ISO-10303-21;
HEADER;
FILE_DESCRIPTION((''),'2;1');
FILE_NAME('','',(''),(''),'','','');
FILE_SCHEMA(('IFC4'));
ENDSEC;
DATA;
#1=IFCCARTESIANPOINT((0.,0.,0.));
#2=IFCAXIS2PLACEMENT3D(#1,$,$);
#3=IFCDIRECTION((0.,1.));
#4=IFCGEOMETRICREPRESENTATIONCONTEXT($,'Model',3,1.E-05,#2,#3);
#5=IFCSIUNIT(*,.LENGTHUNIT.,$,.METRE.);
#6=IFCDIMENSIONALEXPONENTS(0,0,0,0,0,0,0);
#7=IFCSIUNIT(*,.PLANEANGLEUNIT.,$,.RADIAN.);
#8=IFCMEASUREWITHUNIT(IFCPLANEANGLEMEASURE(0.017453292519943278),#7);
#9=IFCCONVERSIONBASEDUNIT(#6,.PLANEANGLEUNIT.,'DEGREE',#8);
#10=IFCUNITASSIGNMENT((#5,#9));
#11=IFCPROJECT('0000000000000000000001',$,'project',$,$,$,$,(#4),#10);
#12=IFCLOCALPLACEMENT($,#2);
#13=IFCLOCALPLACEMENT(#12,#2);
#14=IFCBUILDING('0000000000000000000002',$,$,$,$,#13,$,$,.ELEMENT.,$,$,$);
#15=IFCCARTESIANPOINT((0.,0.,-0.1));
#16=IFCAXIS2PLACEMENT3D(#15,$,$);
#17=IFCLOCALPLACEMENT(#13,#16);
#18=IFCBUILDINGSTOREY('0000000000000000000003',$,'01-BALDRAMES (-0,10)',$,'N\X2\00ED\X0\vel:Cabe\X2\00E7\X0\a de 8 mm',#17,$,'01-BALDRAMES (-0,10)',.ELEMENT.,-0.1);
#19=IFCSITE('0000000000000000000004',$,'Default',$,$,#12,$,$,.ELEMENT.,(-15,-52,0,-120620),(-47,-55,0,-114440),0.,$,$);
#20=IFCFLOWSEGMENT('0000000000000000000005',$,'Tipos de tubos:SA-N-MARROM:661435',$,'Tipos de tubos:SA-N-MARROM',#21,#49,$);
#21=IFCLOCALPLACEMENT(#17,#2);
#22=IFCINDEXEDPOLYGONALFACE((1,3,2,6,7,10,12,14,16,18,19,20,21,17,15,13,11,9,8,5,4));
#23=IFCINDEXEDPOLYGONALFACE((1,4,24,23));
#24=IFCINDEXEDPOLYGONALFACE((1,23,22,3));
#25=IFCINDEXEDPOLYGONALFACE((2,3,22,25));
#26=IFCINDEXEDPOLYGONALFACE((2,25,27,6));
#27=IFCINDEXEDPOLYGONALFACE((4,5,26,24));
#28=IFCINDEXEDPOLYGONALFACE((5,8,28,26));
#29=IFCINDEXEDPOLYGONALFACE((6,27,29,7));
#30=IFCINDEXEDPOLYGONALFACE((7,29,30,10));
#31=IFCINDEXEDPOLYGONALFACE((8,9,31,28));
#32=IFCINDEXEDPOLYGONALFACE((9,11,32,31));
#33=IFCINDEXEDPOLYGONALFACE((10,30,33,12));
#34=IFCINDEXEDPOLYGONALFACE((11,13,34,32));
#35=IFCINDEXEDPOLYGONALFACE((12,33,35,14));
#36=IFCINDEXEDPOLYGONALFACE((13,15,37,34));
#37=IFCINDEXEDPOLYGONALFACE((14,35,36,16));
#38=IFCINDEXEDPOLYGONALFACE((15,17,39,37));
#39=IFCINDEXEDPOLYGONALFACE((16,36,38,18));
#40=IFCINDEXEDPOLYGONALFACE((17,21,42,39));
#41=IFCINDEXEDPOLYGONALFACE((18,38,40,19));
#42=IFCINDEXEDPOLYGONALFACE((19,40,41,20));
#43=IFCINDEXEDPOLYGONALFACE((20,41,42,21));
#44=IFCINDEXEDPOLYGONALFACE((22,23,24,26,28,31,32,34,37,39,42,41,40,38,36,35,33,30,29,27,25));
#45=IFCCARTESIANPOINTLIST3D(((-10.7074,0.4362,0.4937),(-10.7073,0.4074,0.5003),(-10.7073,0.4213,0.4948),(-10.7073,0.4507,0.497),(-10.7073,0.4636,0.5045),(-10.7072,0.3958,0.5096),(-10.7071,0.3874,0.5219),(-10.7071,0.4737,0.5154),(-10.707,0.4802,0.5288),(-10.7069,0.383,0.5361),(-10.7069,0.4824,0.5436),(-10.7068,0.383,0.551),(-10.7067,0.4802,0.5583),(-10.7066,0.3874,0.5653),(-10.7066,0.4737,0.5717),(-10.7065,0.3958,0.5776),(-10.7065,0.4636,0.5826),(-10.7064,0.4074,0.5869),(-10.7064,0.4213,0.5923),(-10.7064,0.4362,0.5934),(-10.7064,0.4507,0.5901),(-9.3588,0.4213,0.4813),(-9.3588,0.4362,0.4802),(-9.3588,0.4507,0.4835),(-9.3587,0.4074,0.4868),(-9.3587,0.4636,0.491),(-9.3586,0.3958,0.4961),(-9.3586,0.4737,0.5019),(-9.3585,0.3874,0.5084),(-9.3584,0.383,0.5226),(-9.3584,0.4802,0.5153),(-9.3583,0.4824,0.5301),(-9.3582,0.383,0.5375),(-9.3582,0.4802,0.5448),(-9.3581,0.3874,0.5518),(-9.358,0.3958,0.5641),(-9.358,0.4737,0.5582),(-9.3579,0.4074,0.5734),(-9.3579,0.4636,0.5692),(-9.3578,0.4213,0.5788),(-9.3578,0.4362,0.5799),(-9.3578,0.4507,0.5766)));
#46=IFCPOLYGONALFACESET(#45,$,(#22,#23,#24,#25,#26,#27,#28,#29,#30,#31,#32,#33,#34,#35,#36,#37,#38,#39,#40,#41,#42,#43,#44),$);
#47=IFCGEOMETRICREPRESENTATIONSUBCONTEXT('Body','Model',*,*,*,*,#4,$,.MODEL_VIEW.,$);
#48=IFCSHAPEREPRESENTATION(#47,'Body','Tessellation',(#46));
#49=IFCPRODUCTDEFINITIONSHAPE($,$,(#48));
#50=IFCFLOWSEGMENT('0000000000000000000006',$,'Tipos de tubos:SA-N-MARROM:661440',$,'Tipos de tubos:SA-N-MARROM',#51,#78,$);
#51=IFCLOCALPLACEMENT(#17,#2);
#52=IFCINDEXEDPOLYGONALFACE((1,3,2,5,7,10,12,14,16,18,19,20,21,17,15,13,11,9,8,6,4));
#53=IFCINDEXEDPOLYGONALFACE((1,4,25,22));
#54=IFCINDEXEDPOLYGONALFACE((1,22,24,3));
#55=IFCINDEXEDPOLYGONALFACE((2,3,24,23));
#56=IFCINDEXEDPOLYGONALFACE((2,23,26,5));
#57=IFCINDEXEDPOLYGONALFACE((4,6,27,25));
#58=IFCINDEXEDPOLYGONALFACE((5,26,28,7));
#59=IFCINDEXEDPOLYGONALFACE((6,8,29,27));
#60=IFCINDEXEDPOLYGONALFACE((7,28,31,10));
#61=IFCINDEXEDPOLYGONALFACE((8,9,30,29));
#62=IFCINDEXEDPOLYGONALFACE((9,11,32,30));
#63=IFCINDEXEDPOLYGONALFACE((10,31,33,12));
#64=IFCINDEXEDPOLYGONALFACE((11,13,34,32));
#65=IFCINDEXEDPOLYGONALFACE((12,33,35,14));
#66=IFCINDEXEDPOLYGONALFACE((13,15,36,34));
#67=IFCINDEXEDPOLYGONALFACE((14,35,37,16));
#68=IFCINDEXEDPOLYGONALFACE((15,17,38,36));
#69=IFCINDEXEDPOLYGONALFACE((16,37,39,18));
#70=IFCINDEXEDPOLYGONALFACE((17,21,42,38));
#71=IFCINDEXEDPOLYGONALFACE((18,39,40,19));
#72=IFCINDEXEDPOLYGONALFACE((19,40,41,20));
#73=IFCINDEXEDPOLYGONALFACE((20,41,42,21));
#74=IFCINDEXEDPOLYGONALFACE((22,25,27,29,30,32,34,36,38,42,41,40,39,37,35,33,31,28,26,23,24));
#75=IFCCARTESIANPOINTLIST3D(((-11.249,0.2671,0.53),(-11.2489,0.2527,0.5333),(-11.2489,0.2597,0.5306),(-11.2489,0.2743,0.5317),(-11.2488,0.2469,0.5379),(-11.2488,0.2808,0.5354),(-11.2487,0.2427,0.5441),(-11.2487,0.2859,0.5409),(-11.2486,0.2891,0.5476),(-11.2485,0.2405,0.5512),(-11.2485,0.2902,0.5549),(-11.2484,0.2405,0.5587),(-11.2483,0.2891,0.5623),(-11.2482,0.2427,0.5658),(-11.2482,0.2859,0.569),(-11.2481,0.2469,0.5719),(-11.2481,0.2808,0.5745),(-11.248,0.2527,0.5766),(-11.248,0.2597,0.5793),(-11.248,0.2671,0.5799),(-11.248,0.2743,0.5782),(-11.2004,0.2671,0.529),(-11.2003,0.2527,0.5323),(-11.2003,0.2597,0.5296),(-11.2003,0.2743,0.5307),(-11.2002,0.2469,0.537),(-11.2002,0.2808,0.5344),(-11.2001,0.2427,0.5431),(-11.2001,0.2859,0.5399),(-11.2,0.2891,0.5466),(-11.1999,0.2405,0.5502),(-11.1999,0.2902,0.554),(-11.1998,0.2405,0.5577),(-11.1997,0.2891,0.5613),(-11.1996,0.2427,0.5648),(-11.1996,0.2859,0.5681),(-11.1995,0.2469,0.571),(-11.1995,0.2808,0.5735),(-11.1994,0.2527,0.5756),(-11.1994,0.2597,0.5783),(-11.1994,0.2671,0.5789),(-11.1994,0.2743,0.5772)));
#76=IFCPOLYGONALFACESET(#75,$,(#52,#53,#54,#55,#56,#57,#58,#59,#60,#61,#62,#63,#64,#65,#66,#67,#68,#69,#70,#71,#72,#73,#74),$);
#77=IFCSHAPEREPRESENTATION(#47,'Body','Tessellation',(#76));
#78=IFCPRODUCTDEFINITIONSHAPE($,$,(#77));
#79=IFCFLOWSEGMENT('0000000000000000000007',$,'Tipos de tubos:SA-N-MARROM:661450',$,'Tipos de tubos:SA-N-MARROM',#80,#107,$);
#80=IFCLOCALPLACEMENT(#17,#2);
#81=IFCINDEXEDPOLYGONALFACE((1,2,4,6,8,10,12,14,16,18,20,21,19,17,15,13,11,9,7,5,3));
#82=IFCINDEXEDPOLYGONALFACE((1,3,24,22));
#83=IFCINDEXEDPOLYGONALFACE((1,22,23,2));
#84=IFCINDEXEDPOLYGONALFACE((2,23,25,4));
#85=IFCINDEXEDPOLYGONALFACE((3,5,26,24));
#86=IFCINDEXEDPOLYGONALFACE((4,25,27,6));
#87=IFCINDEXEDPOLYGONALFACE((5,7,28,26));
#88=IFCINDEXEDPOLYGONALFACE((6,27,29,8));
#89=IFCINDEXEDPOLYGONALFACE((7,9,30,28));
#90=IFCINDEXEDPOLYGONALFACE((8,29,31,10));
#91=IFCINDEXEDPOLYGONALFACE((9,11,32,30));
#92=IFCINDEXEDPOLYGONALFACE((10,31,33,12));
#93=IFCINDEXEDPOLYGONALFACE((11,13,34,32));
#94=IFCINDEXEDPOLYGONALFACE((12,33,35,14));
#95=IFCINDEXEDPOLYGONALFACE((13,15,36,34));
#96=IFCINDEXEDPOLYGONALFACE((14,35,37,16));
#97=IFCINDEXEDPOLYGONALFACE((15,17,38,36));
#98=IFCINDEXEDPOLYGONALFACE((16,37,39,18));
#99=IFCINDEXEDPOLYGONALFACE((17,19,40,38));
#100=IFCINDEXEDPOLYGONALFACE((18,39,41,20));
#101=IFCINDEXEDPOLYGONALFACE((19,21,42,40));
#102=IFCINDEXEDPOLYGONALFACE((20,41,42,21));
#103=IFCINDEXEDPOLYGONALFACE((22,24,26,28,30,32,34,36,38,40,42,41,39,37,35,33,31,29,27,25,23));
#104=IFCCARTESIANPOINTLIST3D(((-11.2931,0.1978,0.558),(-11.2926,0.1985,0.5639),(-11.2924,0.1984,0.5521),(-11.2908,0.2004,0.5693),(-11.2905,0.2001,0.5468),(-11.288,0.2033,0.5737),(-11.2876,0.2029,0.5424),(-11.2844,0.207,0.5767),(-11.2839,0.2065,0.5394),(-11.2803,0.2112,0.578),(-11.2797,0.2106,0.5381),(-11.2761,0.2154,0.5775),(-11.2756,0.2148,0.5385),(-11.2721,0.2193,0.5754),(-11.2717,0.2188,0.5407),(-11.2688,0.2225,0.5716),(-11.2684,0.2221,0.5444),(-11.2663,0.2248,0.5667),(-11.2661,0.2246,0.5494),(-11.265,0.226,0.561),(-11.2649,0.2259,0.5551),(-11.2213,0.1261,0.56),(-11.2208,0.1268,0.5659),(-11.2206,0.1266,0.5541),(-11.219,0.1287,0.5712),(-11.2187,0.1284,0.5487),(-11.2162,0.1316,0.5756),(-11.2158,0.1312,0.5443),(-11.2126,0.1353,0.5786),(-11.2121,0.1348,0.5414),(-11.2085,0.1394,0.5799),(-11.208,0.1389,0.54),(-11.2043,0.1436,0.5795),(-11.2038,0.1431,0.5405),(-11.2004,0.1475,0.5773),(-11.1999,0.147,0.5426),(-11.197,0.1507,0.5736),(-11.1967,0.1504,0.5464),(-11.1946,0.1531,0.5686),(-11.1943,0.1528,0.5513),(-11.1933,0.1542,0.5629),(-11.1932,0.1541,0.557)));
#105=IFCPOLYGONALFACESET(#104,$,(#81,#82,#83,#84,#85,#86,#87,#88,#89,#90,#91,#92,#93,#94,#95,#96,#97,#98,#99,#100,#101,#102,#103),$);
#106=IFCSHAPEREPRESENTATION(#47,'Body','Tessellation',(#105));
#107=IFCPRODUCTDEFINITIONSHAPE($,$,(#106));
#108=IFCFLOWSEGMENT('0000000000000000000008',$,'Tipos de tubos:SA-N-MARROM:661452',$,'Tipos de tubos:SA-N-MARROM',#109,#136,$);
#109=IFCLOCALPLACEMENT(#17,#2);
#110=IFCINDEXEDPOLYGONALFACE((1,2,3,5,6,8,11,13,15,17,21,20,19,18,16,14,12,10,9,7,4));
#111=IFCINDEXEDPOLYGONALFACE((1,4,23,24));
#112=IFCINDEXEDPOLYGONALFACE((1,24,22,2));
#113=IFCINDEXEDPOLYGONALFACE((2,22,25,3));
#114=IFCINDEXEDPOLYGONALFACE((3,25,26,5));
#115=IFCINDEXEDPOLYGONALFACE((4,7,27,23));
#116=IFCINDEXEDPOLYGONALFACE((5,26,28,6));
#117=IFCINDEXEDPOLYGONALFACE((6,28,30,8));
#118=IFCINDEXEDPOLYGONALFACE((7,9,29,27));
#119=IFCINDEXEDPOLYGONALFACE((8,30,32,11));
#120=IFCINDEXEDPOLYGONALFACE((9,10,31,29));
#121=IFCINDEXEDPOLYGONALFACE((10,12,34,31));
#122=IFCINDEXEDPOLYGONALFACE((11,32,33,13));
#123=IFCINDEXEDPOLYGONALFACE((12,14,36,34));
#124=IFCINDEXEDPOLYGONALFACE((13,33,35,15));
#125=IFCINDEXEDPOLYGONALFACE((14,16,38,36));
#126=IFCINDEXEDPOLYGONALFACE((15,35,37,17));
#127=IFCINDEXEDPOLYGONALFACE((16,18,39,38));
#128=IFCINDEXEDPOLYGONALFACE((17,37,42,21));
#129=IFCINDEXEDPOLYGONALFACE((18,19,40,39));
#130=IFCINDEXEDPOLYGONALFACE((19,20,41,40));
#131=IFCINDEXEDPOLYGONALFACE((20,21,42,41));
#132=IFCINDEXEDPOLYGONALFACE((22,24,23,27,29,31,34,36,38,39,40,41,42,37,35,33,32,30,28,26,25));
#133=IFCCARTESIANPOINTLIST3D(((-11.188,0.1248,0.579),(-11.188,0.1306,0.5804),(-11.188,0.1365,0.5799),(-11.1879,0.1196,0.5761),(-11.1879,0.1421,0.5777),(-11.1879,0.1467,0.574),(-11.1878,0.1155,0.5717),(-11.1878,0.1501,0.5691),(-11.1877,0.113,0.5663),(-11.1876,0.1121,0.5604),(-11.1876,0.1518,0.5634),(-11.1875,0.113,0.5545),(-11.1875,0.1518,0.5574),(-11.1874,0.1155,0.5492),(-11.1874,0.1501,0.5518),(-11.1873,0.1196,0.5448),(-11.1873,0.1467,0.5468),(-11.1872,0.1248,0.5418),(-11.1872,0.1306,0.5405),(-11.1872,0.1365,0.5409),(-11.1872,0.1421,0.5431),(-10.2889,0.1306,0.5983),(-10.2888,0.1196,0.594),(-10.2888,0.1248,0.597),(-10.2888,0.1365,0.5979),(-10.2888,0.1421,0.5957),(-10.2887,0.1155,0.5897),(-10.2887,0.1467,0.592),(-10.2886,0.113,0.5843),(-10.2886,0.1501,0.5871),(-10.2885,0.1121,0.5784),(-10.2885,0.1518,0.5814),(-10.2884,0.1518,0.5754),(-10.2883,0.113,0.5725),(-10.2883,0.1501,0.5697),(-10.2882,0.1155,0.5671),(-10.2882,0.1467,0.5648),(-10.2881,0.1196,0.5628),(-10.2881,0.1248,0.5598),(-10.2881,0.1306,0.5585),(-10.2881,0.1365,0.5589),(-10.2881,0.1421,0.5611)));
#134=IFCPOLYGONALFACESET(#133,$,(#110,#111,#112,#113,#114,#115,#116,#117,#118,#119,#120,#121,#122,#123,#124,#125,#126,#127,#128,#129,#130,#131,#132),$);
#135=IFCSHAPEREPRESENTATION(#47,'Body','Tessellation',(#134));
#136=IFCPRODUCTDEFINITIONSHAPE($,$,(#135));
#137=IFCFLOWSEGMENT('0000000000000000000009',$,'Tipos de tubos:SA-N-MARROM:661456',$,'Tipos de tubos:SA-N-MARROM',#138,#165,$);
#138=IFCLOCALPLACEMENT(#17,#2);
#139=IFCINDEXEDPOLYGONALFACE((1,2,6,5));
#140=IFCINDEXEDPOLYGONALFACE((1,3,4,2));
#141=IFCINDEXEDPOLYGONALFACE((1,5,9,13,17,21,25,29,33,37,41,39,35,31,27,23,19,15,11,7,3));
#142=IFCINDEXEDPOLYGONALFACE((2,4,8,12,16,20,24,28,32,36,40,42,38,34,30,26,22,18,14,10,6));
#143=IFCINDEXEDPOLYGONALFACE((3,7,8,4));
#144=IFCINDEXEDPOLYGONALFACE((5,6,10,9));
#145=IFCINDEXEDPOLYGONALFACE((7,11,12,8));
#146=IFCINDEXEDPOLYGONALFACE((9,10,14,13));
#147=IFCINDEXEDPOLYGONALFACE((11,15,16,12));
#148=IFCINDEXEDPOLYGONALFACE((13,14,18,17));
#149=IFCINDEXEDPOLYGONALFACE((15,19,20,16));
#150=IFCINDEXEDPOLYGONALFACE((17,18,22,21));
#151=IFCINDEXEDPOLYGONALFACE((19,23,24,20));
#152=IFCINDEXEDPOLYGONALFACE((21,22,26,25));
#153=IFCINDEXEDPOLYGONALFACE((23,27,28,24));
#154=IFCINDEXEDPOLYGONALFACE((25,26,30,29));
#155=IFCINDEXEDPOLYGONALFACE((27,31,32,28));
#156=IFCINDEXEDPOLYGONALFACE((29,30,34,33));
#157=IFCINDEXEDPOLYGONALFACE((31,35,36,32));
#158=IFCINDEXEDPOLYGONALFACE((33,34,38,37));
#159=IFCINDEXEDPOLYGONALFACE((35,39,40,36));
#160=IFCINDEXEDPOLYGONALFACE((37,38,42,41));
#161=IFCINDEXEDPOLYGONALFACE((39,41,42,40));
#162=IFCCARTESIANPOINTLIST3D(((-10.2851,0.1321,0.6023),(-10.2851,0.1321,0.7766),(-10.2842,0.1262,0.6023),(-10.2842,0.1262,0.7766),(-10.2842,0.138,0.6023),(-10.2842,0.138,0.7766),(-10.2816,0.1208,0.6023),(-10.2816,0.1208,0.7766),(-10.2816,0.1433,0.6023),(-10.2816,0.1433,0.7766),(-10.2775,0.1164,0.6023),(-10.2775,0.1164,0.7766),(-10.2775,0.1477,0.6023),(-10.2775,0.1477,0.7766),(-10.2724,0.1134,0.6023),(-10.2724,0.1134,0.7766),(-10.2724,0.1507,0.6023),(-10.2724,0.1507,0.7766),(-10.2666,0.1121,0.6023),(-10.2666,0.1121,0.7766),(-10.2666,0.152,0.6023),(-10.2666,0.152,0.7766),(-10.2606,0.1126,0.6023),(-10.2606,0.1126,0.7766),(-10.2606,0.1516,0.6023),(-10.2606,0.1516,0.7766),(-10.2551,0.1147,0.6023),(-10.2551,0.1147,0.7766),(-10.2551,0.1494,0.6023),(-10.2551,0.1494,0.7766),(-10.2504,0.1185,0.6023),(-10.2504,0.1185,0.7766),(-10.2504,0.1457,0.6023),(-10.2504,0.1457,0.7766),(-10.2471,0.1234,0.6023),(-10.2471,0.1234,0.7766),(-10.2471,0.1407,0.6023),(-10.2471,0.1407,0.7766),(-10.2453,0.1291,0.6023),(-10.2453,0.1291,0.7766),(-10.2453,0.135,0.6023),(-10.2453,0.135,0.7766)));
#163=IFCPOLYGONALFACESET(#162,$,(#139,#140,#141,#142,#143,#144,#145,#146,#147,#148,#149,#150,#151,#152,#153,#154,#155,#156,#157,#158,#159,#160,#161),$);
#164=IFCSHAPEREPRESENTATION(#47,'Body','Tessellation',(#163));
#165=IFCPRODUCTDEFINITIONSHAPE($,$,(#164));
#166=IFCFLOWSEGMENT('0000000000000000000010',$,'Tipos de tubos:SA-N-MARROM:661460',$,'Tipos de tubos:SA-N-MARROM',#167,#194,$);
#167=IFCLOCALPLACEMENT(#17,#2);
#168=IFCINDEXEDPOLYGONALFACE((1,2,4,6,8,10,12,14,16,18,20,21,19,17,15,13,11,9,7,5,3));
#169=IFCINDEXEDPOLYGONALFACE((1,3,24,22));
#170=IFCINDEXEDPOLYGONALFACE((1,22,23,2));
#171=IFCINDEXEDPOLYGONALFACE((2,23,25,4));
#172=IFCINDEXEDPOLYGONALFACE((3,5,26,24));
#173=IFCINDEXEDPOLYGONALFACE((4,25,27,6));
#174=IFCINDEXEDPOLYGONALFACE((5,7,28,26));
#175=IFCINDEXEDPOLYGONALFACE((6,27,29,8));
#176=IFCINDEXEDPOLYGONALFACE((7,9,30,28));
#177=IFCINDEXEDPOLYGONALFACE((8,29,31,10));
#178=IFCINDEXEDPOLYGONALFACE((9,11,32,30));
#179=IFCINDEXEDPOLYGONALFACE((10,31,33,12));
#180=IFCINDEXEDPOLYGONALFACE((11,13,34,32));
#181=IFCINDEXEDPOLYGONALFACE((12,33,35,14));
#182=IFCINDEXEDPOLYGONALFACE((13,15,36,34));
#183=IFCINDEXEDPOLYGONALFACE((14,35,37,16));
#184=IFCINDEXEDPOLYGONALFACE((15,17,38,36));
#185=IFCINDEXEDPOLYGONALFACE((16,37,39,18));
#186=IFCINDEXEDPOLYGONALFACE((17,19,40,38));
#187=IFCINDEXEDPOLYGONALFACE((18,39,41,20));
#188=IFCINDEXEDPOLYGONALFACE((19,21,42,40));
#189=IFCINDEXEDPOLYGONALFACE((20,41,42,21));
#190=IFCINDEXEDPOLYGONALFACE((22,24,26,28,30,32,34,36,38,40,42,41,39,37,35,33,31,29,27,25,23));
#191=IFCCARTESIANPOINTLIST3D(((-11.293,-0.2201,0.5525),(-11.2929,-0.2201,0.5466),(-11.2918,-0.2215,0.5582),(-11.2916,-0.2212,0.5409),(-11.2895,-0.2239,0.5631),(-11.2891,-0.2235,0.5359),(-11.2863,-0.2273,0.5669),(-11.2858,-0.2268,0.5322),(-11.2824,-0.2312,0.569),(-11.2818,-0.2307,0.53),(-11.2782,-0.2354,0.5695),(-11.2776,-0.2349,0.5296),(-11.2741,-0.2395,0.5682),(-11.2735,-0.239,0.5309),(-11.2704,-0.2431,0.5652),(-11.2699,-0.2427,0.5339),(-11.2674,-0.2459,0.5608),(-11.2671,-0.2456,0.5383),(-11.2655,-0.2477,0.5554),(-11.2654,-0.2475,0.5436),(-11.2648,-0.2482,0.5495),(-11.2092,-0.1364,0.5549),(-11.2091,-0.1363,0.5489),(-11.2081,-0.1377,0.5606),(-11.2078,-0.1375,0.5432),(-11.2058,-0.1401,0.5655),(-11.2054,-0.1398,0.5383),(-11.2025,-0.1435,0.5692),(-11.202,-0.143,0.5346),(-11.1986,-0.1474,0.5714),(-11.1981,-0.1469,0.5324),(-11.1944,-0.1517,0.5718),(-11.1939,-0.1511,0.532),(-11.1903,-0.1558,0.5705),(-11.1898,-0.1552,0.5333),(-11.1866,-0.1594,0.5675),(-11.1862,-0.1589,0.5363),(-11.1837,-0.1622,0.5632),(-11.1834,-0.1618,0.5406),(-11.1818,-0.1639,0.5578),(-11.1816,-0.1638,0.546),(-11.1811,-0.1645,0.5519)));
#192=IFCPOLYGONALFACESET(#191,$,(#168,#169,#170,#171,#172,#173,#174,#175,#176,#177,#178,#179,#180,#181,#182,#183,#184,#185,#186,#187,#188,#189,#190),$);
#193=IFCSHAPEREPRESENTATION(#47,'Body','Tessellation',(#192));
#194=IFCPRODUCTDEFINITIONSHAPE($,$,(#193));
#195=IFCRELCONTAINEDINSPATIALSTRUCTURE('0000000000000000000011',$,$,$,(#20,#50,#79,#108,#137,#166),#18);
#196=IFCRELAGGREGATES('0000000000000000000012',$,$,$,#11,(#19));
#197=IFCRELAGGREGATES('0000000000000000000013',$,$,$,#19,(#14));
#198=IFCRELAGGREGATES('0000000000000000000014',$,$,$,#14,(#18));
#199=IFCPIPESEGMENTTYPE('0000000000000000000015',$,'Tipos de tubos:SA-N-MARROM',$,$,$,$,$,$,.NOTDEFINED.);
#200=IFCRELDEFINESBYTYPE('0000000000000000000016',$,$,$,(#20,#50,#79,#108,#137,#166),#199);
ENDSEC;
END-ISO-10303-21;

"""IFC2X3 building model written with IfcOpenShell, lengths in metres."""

from ifc_helpers import new_model, entity, si_unit, converted_unit, direction, frame, frame_2d, origin, place, context, subcontext, project, spatial, circle, extrude, type_object, element, save


model = new_model("IFC2X3")

# Units and contexts
model_context = context("Model", 3, precision=1e-05, world=origin(), true_north=direction((0.0, 1.0)))
body_context = subcontext(model_context, "Body", "Model", "MODEL_VIEW")
ifc_project = project(units=[si_unit("LENGTHUNIT", "METRE"), converted_unit("PLANEANGLEUNIT", "DEGREE", entity("IfcPlaneAngleMeasure", 0.017453292519943278), si_unit("PLANEANGLEUNIT", "RADIAN"), dimensions=[0, 0, 0, 0, 0, 0, 0])], contexts=[model_context])

# Site, building, storey
site_placement = place(None, origin())
site = spatial("IfcSite", under=ifc_project, at=site_placement, Name="Default", CompositionType="ELEMENT", RefLatitude=(-15, -52, 0, -120620), RefLongitude=(-47, -55, 0, -114440), RefElevation=0.0)
building_placement = place(site_placement, origin())
building = spatial("IfcBuilding", under=site, at=building_placement, CompositionType="ELEMENT")
storey_placement = place(building_placement, frame((0.0, 0.0, -0.1)))
storey = spatial("IfcBuildingStorey", under=building, at=storey_placement, Name="01-BALDRAMES (-0,10)", ObjectType="Nível:Cabeça de 8 mm", LongName="01-BALDRAMES (-0,10)", CompositionType="ELEMENT", Elevation=-0.1)

# Flow segments
pipe_segment_type_1 = type_object("IfcPipeSegmentType", Name="Tipos de tubos:SA-N-MARROM", PredefinedType="NOTDEFINED")
flow_segment_1_placement = place(storey_placement, origin())
element("IfcFlowSegment", 1, at=flow_segment_1_placement, inside=storey, type_object=pipe_segment_type_1, Name="Tipos de tubos:SA-N-MARROM:661435", ObjectType="Tipos de tubos:SA-N-MARROM", context=body_context, shape_type="SweptSolid", body=[
    extrude(circle(Radius=0.05, at=frame_2d((0.0, 0.0), x_axis=(1.0, 0.0))), frame((-10.7069, 0.4324, 0.5436), z_axis=(0.99995, 0.000001, -0.01), x_axis=(-0.000001, 1.0, 0.0)), (0.0, 0.0, 1.0), 1.3486),
])
flow_segment_2_placement = place(storey_placement, origin())
element("IfcFlowSegment", 2, at=flow_segment_2_placement, inside=storey, type_object=pipe_segment_type_1, Name="Tipos de tubos:SA-N-MARROM:661440", ObjectType="Tipos de tubos:SA-N-MARROM", context=body_context, shape_type="SweptSolid", body=[
    extrude(circle(Radius=0.025, at=frame_2d((0.0, 0.0), x_axis=(1.0, 0.0))), frame((-11.2485, 0.2652, 0.5549), z_axis=(0.9998, 0.000001, -0.019996), x_axis=(-0.000001, 1.0, 0.0)), (0.0, 0.0, 1.0), 0.0486),
])
flow_segment_3_placement = place(storey_placement, origin())
element("IfcFlowSegment", 3, at=flow_segment_3_placement, inside=storey, type_object=pipe_segment_type_1, Name="Tipos de tubos:SA-N-MARROM:661450", ObjectType="Tipos de tubos:SA-N-MARROM", context=body_context, shape_type="SweptSolid", body=[
    extrude(circle(Radius=0.02, at=frame_2d((0.0, 0.0), x_axis=(1.0, 0.0))), frame((-11.279, 0.2119, 0.558), z_axis=(0.706979, -0.706979, 0.019017), x_axis=(-0.707106, -0.707107, 0.0)), (0.0, 0.0, 1.0), 0.1015),
])
flow_segment_4_placement = place(storey_placement, origin())
element("IfcFlowSegment", 4, at=flow_segment_4_placement, inside=storey, type_object=pipe_segment_type_1, Name="Tipos de tubos:SA-N-MARROM:661452", ObjectType="Tipos de tubos:SA-N-MARROM", context=body_context, shape_type="SweptSolid", body=[
    extrude(circle(Radius=0.02, at=frame_2d((0.0, 0.0), x_axis=(1.0, 0.0))), frame((-11.1876, 0.1321, 0.5604), z_axis=(0.9998, 0.000001, 0.019996), x_axis=(0.000001, -1.0, 0.0)), (0.0, 0.0, 1.0), 0.8993),
])
flow_segment_5_placement = place(storey_placement, origin())
element("IfcFlowSegment", 5, at=flow_segment_5_placement, inside=storey, type_object=pipe_segment_type_1, Name="Tipos de tubos:SA-N-MARROM:661456", ObjectType="Tipos de tubos:SA-N-MARROM", context=body_context, shape_type="SweptSolid", body=[
    extrude(circle(Radius=0.02, at=frame_2d((0.0, 0.0), x_axis=(1.0, 0.0))), frame((-10.2651, 0.1321, 0.6023), z_axis=(0.0, 0.0, 1.0), x_axis=(-1.0, 0.0, 0.0)), (0.0, 0.0, 1.0), 0.1744),
])
flow_segment_6_placement = place(storey_placement, origin())
element("IfcFlowSegment", 6, at=flow_segment_6_placement, inside=storey, type_object=pipe_segment_type_1, Name="Tipos de tubos:SA-N-MARROM:661460", ObjectType="Tipos de tubos:SA-N-MARROM", context=body_context, shape_type="SweptSolid", body=[
    extrude(circle(Radius=0.02, at=frame_2d((0.0, 0.0), x_axis=(1.0, 0.0))), frame((-11.279, -0.2341, 0.5495), z_axis=(0.706965, 0.706966, 0.019996), x_axis=(0.707107, -0.707106, 0.0)), (0.0, 0.0, 1.0), 0.1185),
])

save(model, "model.ifc")
